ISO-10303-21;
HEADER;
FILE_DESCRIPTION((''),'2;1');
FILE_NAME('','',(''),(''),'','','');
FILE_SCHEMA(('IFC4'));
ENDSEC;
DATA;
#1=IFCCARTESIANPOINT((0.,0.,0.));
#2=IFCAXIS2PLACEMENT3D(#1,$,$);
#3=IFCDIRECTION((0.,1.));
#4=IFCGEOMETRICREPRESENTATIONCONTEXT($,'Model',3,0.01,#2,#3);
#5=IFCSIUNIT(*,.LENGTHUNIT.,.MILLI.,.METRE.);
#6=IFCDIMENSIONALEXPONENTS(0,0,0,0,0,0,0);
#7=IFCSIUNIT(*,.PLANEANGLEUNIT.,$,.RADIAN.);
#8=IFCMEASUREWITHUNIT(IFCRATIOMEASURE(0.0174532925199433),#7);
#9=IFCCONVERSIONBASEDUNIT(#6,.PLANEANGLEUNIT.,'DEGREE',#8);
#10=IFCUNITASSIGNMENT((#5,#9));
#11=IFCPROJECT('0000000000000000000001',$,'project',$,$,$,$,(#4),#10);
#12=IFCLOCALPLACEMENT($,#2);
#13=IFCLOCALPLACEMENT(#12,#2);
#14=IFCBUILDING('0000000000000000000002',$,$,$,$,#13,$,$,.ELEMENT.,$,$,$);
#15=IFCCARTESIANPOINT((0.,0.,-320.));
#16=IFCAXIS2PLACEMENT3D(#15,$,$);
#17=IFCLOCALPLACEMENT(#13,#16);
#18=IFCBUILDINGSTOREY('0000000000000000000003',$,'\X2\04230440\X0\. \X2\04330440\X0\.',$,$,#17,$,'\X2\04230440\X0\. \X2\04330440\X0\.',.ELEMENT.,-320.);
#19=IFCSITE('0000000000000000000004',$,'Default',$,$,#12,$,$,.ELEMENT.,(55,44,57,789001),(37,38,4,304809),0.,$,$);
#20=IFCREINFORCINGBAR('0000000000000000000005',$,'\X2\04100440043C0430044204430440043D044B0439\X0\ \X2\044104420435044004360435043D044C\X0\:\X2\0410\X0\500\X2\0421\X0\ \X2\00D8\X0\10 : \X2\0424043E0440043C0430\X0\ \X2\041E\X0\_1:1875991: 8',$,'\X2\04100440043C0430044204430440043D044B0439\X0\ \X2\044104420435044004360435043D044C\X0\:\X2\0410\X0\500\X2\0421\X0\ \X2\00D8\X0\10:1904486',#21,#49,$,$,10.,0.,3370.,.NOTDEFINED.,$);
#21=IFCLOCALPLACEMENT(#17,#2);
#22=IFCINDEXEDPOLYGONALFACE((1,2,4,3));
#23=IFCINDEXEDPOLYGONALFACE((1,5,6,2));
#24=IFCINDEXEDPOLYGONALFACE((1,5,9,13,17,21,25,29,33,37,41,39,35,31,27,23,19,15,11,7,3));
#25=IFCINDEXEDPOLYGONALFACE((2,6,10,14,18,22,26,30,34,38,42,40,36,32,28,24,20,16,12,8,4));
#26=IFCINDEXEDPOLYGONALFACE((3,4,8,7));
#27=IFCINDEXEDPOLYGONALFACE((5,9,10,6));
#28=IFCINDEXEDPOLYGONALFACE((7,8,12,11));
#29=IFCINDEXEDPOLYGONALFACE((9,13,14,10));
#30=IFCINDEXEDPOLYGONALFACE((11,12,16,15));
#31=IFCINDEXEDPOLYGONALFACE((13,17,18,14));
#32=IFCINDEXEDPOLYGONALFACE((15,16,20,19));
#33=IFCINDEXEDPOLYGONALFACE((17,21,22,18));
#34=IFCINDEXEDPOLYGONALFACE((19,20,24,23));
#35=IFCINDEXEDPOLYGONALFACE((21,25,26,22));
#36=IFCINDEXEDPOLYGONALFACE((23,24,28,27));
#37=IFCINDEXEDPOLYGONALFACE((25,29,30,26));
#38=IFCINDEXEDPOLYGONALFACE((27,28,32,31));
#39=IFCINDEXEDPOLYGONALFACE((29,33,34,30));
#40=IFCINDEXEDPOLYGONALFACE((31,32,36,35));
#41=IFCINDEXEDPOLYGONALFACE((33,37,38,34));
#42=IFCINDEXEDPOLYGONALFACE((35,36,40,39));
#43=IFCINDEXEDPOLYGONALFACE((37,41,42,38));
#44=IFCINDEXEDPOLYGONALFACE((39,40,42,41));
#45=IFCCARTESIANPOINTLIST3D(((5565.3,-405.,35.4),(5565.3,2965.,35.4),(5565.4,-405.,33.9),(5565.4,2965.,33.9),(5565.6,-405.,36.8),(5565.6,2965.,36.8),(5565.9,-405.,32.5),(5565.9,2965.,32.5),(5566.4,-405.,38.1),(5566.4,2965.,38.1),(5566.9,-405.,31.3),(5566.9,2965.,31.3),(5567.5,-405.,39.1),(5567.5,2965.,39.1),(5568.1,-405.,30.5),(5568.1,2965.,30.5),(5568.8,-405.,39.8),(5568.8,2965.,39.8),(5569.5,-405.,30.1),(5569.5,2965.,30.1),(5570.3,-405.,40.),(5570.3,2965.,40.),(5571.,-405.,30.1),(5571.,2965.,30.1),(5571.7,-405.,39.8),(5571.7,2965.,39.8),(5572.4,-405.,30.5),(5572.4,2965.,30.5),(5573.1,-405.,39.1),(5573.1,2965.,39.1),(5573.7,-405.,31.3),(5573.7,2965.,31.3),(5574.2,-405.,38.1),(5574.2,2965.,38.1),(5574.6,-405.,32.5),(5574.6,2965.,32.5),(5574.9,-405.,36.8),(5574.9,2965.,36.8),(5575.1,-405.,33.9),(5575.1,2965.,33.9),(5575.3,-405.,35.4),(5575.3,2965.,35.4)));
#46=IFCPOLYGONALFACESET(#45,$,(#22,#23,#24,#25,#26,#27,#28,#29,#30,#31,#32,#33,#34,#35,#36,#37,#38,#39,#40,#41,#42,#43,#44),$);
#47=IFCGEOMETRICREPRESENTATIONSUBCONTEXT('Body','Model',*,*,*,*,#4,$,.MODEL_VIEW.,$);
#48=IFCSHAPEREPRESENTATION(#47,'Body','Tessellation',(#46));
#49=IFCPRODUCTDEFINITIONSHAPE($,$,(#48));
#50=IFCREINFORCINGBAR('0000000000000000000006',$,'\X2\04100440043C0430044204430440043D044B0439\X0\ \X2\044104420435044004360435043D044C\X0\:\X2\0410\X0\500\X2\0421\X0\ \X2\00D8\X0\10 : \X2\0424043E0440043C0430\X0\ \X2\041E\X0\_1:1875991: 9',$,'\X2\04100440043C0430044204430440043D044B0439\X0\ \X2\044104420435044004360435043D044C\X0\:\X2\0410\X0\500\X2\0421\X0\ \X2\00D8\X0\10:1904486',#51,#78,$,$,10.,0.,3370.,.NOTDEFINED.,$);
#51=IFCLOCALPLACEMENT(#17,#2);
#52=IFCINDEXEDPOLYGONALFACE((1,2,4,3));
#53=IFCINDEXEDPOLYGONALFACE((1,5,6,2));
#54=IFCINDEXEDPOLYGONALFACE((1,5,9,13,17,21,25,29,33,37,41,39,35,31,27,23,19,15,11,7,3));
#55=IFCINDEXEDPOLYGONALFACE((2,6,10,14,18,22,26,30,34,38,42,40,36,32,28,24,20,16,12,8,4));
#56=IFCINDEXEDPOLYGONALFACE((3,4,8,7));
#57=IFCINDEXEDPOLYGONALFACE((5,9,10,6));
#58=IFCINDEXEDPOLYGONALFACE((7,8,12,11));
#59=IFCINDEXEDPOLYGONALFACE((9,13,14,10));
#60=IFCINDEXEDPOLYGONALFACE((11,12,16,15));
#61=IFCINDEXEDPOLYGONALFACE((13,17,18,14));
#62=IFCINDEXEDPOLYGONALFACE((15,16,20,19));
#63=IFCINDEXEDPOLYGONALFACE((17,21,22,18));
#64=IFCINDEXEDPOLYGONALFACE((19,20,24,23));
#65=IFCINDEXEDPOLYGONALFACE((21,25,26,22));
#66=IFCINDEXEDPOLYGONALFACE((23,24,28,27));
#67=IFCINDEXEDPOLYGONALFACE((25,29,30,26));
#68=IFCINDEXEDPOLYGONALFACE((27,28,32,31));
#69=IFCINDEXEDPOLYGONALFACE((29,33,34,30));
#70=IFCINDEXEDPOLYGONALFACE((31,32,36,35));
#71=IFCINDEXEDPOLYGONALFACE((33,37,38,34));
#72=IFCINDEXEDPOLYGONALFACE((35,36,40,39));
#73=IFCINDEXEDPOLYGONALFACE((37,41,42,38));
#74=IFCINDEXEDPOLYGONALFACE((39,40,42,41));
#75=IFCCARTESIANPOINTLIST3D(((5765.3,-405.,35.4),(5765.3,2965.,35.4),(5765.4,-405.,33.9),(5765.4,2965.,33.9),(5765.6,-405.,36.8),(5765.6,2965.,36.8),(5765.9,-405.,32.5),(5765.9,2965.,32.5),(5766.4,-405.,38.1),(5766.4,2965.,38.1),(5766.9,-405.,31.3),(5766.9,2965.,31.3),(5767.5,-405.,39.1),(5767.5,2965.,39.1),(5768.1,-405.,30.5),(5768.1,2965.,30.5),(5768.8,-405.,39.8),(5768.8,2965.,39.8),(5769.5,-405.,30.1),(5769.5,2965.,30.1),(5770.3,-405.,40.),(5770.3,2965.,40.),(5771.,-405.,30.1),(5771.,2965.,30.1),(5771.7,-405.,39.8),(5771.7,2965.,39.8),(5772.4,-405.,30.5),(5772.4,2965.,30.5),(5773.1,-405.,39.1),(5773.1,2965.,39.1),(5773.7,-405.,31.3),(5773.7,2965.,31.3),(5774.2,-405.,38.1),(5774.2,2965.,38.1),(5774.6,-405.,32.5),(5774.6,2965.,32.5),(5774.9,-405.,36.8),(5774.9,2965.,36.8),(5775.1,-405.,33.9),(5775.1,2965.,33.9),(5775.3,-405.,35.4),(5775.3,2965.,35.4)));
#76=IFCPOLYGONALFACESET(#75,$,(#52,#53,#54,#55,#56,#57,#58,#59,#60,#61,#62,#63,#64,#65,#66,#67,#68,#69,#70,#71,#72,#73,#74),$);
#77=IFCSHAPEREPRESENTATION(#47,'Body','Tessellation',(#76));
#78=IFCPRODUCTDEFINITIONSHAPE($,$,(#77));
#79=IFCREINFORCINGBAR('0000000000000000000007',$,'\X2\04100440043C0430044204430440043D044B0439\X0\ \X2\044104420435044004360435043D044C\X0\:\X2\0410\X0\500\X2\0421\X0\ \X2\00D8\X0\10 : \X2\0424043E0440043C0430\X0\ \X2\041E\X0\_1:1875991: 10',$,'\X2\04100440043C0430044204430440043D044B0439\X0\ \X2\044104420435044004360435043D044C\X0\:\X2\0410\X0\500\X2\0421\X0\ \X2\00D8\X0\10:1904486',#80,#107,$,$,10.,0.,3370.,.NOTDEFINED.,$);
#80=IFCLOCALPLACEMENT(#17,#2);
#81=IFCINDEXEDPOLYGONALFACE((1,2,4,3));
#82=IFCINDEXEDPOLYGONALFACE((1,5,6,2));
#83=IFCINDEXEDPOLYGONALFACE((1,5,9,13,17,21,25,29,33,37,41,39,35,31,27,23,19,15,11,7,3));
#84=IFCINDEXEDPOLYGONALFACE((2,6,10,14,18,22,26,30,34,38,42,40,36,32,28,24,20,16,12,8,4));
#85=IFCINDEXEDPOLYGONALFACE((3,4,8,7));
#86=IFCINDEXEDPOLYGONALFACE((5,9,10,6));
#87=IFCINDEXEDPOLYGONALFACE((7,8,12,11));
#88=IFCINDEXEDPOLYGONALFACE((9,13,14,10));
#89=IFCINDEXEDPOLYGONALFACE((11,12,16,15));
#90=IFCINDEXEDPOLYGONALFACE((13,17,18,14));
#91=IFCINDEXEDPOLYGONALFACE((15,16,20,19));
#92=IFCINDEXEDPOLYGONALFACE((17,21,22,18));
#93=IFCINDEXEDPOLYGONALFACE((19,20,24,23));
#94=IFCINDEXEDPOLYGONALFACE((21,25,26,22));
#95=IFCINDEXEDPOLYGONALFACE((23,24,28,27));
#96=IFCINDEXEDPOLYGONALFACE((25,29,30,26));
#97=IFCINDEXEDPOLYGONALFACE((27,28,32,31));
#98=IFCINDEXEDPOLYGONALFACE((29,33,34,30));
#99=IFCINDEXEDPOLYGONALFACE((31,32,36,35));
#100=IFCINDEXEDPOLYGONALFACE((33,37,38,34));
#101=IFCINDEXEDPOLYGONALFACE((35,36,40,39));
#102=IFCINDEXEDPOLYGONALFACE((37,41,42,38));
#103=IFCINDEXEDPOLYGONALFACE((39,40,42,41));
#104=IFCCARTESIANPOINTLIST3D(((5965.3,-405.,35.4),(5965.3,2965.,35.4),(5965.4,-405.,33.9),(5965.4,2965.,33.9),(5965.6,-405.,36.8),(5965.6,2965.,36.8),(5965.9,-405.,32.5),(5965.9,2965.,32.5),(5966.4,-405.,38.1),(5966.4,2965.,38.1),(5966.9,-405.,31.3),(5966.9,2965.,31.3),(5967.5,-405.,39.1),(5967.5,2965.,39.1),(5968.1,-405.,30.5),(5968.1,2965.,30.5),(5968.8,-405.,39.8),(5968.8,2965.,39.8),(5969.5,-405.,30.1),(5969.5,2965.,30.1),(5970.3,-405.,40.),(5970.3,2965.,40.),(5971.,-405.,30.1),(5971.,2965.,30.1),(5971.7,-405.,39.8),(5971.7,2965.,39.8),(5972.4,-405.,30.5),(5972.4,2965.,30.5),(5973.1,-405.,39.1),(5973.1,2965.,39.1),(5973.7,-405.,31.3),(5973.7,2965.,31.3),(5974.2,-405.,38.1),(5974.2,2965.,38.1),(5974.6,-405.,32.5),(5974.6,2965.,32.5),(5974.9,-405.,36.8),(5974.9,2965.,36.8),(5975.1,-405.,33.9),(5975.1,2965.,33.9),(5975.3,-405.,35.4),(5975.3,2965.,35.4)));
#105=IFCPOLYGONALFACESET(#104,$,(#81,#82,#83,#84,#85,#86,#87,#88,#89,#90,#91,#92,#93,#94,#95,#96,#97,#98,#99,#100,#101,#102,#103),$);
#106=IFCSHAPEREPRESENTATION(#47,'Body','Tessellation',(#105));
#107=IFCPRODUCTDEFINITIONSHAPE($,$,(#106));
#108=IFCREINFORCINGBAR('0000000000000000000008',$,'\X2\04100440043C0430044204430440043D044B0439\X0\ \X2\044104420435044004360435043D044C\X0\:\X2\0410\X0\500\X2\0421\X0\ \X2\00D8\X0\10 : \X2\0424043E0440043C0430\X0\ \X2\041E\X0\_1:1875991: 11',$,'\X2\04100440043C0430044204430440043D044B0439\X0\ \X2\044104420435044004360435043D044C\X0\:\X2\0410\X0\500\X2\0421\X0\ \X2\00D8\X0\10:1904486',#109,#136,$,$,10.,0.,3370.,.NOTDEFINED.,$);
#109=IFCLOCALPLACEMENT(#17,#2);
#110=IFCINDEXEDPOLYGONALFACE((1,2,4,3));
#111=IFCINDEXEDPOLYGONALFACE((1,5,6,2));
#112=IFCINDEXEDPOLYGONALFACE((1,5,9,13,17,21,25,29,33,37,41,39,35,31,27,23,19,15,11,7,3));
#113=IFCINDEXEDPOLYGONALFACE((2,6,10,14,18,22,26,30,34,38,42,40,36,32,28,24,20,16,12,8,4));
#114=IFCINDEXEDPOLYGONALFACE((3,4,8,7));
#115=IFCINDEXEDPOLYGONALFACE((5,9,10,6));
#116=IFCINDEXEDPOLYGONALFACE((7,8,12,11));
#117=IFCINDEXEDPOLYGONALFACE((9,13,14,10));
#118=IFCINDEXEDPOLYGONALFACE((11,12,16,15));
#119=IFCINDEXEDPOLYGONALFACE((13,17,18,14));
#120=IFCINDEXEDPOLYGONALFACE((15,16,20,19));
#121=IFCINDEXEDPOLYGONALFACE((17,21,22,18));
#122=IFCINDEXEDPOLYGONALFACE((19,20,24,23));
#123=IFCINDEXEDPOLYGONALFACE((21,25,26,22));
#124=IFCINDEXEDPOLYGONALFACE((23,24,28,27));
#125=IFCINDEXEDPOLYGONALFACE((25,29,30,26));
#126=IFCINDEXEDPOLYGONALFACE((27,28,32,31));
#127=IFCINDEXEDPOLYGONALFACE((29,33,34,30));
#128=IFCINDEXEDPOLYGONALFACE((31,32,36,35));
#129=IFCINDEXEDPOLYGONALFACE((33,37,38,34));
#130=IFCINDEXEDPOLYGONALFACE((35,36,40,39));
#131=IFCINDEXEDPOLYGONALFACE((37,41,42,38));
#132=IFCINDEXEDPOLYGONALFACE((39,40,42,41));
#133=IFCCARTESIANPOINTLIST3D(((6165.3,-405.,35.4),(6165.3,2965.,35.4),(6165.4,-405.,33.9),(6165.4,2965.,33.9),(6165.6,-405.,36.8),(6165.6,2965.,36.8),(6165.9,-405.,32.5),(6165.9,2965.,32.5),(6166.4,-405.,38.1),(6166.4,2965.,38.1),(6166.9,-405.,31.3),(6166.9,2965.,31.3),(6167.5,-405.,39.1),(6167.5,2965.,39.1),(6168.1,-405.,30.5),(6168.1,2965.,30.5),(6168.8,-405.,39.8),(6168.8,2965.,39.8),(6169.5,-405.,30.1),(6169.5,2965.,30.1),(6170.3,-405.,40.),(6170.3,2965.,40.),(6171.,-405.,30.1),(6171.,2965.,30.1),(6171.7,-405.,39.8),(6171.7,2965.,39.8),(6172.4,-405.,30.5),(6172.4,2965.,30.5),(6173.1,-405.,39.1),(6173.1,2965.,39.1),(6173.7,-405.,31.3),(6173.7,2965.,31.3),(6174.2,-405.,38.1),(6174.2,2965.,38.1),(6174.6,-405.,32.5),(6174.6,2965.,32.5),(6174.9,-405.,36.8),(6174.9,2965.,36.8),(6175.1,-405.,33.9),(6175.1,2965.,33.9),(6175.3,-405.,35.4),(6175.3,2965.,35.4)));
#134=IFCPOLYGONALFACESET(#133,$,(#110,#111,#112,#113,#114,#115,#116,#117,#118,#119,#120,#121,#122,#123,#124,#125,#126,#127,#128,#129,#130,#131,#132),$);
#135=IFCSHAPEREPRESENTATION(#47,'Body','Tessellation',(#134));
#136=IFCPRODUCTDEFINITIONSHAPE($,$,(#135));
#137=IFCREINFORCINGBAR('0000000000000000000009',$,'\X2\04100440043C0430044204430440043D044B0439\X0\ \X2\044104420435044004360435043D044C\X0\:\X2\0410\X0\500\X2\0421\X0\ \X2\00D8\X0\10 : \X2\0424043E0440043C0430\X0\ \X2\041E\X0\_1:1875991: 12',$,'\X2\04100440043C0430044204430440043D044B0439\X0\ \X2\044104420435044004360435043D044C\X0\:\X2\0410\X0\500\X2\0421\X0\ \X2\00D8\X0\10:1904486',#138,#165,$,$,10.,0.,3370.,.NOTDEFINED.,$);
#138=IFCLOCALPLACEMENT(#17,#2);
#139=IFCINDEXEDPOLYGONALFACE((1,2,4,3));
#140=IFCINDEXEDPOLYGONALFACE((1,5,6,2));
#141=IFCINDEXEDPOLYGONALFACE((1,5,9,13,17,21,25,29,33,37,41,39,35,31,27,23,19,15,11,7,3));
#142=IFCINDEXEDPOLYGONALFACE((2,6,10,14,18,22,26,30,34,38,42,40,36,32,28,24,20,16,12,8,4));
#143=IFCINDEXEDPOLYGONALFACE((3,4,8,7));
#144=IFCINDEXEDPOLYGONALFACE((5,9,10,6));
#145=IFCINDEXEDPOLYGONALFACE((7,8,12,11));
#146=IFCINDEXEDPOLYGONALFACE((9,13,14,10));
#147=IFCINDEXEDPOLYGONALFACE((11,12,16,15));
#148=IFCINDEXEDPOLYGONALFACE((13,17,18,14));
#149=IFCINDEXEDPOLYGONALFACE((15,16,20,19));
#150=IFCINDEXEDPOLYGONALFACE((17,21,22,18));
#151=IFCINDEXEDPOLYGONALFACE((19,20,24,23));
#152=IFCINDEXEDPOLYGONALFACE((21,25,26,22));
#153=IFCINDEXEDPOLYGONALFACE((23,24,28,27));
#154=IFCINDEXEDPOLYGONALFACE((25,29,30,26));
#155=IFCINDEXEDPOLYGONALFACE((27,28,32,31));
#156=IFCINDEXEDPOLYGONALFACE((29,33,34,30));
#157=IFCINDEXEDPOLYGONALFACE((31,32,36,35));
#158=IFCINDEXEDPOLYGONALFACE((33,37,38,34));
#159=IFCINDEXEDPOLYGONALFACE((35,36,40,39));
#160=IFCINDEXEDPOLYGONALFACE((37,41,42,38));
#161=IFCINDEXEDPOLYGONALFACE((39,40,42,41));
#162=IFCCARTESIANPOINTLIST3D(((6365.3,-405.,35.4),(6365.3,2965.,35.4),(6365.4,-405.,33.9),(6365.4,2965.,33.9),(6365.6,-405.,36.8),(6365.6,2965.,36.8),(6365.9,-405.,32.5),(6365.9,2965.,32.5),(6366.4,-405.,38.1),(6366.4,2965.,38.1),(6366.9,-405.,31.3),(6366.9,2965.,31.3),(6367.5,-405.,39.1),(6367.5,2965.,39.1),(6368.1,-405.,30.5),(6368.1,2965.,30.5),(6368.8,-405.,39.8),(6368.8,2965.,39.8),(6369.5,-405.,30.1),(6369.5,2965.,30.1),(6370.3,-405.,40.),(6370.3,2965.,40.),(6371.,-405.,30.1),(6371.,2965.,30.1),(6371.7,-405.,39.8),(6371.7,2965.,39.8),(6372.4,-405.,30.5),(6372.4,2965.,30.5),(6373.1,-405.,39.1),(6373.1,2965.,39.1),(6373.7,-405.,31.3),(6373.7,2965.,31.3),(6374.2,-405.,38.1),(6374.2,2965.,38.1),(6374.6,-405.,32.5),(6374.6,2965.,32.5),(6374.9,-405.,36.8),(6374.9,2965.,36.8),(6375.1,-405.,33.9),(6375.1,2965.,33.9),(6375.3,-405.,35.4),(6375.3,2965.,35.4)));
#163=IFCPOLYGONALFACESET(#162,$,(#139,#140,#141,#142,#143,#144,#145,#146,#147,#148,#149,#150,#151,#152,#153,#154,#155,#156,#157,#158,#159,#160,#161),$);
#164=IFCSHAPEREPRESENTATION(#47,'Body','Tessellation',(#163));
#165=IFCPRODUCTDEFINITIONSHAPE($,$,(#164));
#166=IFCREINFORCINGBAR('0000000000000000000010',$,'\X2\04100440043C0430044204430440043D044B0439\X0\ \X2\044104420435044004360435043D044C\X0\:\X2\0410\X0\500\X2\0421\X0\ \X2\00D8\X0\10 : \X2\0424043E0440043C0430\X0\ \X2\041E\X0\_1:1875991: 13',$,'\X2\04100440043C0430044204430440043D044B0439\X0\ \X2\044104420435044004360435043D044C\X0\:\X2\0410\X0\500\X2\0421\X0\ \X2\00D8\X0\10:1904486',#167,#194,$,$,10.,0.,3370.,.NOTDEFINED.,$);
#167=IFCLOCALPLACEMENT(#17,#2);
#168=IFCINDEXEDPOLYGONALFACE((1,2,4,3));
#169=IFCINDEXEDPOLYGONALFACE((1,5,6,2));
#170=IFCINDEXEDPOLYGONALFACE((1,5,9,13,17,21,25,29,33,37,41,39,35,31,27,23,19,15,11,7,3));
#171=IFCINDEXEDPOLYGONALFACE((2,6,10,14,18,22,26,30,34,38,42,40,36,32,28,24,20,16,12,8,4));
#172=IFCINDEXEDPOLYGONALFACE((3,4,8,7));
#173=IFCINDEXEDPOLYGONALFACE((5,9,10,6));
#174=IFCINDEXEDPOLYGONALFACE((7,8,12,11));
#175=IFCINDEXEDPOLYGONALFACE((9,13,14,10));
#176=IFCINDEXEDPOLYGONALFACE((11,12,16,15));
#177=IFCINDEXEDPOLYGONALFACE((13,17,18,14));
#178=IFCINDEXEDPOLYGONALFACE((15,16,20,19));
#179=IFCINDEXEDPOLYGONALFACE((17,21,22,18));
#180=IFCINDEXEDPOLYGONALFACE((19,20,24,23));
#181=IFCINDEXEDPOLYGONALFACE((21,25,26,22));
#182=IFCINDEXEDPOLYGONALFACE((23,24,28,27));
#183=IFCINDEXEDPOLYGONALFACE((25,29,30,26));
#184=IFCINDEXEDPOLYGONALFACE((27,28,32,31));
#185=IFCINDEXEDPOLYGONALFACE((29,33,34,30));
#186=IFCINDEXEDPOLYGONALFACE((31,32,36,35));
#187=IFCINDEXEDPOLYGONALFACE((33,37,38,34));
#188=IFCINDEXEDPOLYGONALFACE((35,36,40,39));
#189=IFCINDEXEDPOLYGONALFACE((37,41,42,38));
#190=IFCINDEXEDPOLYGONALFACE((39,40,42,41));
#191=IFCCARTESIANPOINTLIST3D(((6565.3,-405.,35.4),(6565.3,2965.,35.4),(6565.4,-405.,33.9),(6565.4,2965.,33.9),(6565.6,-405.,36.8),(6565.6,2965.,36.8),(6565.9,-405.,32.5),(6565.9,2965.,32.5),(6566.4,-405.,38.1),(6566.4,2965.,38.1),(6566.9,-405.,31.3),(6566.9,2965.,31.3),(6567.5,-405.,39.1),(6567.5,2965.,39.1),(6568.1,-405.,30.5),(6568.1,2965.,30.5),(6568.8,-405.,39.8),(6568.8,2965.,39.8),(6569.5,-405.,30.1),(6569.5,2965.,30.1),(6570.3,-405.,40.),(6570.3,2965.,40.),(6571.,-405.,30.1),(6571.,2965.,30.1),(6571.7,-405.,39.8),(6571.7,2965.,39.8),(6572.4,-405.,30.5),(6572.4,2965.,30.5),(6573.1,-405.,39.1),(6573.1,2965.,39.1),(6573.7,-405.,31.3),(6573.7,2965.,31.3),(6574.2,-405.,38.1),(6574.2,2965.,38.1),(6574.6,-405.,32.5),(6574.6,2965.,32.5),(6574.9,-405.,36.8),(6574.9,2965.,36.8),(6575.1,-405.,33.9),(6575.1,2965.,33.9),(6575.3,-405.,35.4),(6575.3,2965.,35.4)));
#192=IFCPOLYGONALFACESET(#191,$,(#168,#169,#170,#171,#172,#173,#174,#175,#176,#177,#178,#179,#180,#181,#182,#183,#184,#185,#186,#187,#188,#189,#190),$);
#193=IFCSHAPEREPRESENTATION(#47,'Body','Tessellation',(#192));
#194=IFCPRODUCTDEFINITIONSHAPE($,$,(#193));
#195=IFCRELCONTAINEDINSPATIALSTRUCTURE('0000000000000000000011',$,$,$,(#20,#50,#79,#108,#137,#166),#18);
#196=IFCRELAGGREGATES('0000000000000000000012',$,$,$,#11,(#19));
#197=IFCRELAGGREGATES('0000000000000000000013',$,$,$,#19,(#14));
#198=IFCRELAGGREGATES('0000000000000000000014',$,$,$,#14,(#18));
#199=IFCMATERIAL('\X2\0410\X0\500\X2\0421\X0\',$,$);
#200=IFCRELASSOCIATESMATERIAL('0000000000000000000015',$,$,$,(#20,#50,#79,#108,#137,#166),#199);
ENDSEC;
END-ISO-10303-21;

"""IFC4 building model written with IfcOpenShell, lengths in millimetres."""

from ifc_helpers import new_model, entity, si_unit, converted_unit, direction, frame, origin, place, context, subcontext, project, spatial, material, element, save


model = new_model("IFC4")

# Units and contexts
model_context = context("Model", 3, precision=0.01, world=origin(), true_north=direction((0.0, 1.0)))
body_context = subcontext(model_context, "Body", "Model", "MODEL_VIEW")
ifc_project = project(units=[si_unit("LENGTHUNIT", "METRE", prefix="MILLI"), converted_unit("PLANEANGLEUNIT", "DEGREE", entity("IfcRatioMeasure", 0.0174532925199433), si_unit("PLANEANGLEUNIT", "RADIAN"), dimensions=[0, 0, 0, 0, 0, 0, 0])], contexts=[model_context])

# Site, building, storey
site_placement = place(None, origin())
site = spatial("IfcSite", under=ifc_project, at=site_placement, Name="Default", CompositionType="ELEMENT", RefLatitude=(55, 44, 57, 789001), RefLongitude=(37, 38, 4, 304809), RefElevation=0.0)
building_placement = place(site_placement, origin())
building = spatial("IfcBuilding", under=site, at=building_placement, CompositionType="ELEMENT")
storey_placement = place(building_placement, frame((0.0, 0.0, -320.0)))
storey = spatial("IfcBuildingStorey", under=building, at=storey_placement, Name="Ур. гр.", LongName="Ур. гр.", CompositionType="ELEMENT", Elevation=-320.0)

# Reinforcing bars
ifc_material_1 = material(Name="А500С")
reinforcing_bar_1_placement = place(storey_placement, origin())
element("IfcReinforcingBar", 1, at=reinforcing_bar_1_placement, inside=storey, material=ifc_material_1, Name="Арматурный стержень:А500С Ø10 : Форма О_1:1875991: 8", ObjectType="Арматурный стержень:А500С Ø10:1904486", BarLength=3370.0, CrossSectionArea=0.0, NominalDiameter=10.0, PredefinedType="NOTDEFINED", context=body_context, shape_type="AdvancedSweptSolid", body=[
    entity("IfcSweptDiskSolid", entity("IfcCompositeCurve", [entity("IfcCompositeCurveSegment", "CONTINUOUS", True, entity("IfcPolyline", [entity("IfcCartesianPoint", [5570.3, -405.0, 35.0]), entity("IfcCartesianPoint", [5570.3, 2965.0, 35.0])]))], False), 5.0, None, 0.0, 1.0),
])
reinforcing_bar_2_placement = place(storey_placement, origin())
element("IfcReinforcingBar", 2, at=reinforcing_bar_2_placement, inside=storey, material=ifc_material_1, Name="Арматурный стержень:А500С Ø10 : Форма О_1:1875991: 9", ObjectType="Арматурный стержень:А500С Ø10:1904486", BarLength=3370.0, CrossSectionArea=0.0, NominalDiameter=10.0, PredefinedType="NOTDEFINED", context=body_context, shape_type="AdvancedSweptSolid", body=[
    entity("IfcSweptDiskSolid", entity("IfcCompositeCurve", [entity("IfcCompositeCurveSegment", "CONTINUOUS", True, entity("IfcPolyline", [entity("IfcCartesianPoint", [5770.3, -405.0, 35.0]), entity("IfcCartesianPoint", [5770.3, 2965.0, 35.0])]))], False), 5.0, None, 0.0, 1.0),
])
reinforcing_bar_3_placement = place(storey_placement, origin())
element("IfcReinforcingBar", 3, at=reinforcing_bar_3_placement, inside=storey, material=ifc_material_1, Name="Арматурный стержень:А500С Ø10 : Форма О_1:1875991: 10", ObjectType="Арматурный стержень:А500С Ø10:1904486", BarLength=3370.0, CrossSectionArea=0.0, NominalDiameter=10.0, PredefinedType="NOTDEFINED", context=body_context, shape_type="AdvancedSweptSolid", body=[
    entity("IfcSweptDiskSolid", entity("IfcCompositeCurve", [entity("IfcCompositeCurveSegment", "CONTINUOUS", True, entity("IfcPolyline", [entity("IfcCartesianPoint", [5970.3, -405.0, 35.0]), entity("IfcCartesianPoint", [5970.3, 2965.0, 35.0])]))], False), 5.0, None, 0.0, 1.0),
])
reinforcing_bar_4_placement = place(storey_placement, origin())
element("IfcReinforcingBar", 4, at=reinforcing_bar_4_placement, inside=storey, material=ifc_material_1, Name="Арматурный стержень:А500С Ø10 : Форма О_1:1875991: 11", ObjectType="Арматурный стержень:А500С Ø10:1904486", BarLength=3370.0, CrossSectionArea=0.0, NominalDiameter=10.0, PredefinedType="NOTDEFINED", context=body_context, shape_type="AdvancedSweptSolid", body=[
    entity("IfcSweptDiskSolid", entity("IfcCompositeCurve", [entity("IfcCompositeCurveSegment", "CONTINUOUS", True, entity("IfcPolyline", [entity("IfcCartesianPoint", [6170.3, -405.0, 35.0]), entity("IfcCartesianPoint", [6170.3, 2965.0, 35.0])]))], False), 5.0, None, 0.0, 1.0),
])
reinforcing_bar_5_placement = place(storey_placement, origin())
element("IfcReinforcingBar", 5, at=reinforcing_bar_5_placement, inside=storey, material=ifc_material_1, Name="Арматурный стержень:А500С Ø10 : Форма О_1:1875991: 12", ObjectType="Арматурный стержень:А500С Ø10:1904486", BarLength=3370.0, CrossSectionArea=0.0, NominalDiameter=10.0, PredefinedType="NOTDEFINED", context=body_context, shape_type="AdvancedSweptSolid", body=[
    entity("IfcSweptDiskSolid", entity("IfcCompositeCurve", [entity("IfcCompositeCurveSegment", "CONTINUOUS", True, entity("IfcPolyline", [entity("IfcCartesianPoint", [6370.3, -405.0, 35.0]), entity("IfcCartesianPoint", [6370.3, 2965.0, 35.0])]))], False), 5.0, None, 0.0, 1.0),
])
reinforcing_bar_6_placement = place(storey_placement, origin())
element("IfcReinforcingBar", 6, at=reinforcing_bar_6_placement, inside=storey, material=ifc_material_1, Name="Арматурный стержень:А500С Ø10 : Форма О_1:1875991: 13", ObjectType="Арматурный стержень:А500С Ø10:1904486", BarLength=3370.0, CrossSectionArea=0.0, NominalDiameter=10.0, PredefinedType="NOTDEFINED", context=body_context, shape_type="AdvancedSweptSolid", body=[
    entity("IfcSweptDiskSolid", entity("IfcCompositeCurve", [entity("IfcCompositeCurveSegment", "CONTINUOUS", True, entity("IfcPolyline", [entity("IfcCartesianPoint", [6570.3, -405.0, 35.0]), entity("IfcCartesianPoint", [6570.3, 2965.0, 35.0])]))], False), 5.0, None, 0.0, 1.0),
])

save(model, "model.ifc")
